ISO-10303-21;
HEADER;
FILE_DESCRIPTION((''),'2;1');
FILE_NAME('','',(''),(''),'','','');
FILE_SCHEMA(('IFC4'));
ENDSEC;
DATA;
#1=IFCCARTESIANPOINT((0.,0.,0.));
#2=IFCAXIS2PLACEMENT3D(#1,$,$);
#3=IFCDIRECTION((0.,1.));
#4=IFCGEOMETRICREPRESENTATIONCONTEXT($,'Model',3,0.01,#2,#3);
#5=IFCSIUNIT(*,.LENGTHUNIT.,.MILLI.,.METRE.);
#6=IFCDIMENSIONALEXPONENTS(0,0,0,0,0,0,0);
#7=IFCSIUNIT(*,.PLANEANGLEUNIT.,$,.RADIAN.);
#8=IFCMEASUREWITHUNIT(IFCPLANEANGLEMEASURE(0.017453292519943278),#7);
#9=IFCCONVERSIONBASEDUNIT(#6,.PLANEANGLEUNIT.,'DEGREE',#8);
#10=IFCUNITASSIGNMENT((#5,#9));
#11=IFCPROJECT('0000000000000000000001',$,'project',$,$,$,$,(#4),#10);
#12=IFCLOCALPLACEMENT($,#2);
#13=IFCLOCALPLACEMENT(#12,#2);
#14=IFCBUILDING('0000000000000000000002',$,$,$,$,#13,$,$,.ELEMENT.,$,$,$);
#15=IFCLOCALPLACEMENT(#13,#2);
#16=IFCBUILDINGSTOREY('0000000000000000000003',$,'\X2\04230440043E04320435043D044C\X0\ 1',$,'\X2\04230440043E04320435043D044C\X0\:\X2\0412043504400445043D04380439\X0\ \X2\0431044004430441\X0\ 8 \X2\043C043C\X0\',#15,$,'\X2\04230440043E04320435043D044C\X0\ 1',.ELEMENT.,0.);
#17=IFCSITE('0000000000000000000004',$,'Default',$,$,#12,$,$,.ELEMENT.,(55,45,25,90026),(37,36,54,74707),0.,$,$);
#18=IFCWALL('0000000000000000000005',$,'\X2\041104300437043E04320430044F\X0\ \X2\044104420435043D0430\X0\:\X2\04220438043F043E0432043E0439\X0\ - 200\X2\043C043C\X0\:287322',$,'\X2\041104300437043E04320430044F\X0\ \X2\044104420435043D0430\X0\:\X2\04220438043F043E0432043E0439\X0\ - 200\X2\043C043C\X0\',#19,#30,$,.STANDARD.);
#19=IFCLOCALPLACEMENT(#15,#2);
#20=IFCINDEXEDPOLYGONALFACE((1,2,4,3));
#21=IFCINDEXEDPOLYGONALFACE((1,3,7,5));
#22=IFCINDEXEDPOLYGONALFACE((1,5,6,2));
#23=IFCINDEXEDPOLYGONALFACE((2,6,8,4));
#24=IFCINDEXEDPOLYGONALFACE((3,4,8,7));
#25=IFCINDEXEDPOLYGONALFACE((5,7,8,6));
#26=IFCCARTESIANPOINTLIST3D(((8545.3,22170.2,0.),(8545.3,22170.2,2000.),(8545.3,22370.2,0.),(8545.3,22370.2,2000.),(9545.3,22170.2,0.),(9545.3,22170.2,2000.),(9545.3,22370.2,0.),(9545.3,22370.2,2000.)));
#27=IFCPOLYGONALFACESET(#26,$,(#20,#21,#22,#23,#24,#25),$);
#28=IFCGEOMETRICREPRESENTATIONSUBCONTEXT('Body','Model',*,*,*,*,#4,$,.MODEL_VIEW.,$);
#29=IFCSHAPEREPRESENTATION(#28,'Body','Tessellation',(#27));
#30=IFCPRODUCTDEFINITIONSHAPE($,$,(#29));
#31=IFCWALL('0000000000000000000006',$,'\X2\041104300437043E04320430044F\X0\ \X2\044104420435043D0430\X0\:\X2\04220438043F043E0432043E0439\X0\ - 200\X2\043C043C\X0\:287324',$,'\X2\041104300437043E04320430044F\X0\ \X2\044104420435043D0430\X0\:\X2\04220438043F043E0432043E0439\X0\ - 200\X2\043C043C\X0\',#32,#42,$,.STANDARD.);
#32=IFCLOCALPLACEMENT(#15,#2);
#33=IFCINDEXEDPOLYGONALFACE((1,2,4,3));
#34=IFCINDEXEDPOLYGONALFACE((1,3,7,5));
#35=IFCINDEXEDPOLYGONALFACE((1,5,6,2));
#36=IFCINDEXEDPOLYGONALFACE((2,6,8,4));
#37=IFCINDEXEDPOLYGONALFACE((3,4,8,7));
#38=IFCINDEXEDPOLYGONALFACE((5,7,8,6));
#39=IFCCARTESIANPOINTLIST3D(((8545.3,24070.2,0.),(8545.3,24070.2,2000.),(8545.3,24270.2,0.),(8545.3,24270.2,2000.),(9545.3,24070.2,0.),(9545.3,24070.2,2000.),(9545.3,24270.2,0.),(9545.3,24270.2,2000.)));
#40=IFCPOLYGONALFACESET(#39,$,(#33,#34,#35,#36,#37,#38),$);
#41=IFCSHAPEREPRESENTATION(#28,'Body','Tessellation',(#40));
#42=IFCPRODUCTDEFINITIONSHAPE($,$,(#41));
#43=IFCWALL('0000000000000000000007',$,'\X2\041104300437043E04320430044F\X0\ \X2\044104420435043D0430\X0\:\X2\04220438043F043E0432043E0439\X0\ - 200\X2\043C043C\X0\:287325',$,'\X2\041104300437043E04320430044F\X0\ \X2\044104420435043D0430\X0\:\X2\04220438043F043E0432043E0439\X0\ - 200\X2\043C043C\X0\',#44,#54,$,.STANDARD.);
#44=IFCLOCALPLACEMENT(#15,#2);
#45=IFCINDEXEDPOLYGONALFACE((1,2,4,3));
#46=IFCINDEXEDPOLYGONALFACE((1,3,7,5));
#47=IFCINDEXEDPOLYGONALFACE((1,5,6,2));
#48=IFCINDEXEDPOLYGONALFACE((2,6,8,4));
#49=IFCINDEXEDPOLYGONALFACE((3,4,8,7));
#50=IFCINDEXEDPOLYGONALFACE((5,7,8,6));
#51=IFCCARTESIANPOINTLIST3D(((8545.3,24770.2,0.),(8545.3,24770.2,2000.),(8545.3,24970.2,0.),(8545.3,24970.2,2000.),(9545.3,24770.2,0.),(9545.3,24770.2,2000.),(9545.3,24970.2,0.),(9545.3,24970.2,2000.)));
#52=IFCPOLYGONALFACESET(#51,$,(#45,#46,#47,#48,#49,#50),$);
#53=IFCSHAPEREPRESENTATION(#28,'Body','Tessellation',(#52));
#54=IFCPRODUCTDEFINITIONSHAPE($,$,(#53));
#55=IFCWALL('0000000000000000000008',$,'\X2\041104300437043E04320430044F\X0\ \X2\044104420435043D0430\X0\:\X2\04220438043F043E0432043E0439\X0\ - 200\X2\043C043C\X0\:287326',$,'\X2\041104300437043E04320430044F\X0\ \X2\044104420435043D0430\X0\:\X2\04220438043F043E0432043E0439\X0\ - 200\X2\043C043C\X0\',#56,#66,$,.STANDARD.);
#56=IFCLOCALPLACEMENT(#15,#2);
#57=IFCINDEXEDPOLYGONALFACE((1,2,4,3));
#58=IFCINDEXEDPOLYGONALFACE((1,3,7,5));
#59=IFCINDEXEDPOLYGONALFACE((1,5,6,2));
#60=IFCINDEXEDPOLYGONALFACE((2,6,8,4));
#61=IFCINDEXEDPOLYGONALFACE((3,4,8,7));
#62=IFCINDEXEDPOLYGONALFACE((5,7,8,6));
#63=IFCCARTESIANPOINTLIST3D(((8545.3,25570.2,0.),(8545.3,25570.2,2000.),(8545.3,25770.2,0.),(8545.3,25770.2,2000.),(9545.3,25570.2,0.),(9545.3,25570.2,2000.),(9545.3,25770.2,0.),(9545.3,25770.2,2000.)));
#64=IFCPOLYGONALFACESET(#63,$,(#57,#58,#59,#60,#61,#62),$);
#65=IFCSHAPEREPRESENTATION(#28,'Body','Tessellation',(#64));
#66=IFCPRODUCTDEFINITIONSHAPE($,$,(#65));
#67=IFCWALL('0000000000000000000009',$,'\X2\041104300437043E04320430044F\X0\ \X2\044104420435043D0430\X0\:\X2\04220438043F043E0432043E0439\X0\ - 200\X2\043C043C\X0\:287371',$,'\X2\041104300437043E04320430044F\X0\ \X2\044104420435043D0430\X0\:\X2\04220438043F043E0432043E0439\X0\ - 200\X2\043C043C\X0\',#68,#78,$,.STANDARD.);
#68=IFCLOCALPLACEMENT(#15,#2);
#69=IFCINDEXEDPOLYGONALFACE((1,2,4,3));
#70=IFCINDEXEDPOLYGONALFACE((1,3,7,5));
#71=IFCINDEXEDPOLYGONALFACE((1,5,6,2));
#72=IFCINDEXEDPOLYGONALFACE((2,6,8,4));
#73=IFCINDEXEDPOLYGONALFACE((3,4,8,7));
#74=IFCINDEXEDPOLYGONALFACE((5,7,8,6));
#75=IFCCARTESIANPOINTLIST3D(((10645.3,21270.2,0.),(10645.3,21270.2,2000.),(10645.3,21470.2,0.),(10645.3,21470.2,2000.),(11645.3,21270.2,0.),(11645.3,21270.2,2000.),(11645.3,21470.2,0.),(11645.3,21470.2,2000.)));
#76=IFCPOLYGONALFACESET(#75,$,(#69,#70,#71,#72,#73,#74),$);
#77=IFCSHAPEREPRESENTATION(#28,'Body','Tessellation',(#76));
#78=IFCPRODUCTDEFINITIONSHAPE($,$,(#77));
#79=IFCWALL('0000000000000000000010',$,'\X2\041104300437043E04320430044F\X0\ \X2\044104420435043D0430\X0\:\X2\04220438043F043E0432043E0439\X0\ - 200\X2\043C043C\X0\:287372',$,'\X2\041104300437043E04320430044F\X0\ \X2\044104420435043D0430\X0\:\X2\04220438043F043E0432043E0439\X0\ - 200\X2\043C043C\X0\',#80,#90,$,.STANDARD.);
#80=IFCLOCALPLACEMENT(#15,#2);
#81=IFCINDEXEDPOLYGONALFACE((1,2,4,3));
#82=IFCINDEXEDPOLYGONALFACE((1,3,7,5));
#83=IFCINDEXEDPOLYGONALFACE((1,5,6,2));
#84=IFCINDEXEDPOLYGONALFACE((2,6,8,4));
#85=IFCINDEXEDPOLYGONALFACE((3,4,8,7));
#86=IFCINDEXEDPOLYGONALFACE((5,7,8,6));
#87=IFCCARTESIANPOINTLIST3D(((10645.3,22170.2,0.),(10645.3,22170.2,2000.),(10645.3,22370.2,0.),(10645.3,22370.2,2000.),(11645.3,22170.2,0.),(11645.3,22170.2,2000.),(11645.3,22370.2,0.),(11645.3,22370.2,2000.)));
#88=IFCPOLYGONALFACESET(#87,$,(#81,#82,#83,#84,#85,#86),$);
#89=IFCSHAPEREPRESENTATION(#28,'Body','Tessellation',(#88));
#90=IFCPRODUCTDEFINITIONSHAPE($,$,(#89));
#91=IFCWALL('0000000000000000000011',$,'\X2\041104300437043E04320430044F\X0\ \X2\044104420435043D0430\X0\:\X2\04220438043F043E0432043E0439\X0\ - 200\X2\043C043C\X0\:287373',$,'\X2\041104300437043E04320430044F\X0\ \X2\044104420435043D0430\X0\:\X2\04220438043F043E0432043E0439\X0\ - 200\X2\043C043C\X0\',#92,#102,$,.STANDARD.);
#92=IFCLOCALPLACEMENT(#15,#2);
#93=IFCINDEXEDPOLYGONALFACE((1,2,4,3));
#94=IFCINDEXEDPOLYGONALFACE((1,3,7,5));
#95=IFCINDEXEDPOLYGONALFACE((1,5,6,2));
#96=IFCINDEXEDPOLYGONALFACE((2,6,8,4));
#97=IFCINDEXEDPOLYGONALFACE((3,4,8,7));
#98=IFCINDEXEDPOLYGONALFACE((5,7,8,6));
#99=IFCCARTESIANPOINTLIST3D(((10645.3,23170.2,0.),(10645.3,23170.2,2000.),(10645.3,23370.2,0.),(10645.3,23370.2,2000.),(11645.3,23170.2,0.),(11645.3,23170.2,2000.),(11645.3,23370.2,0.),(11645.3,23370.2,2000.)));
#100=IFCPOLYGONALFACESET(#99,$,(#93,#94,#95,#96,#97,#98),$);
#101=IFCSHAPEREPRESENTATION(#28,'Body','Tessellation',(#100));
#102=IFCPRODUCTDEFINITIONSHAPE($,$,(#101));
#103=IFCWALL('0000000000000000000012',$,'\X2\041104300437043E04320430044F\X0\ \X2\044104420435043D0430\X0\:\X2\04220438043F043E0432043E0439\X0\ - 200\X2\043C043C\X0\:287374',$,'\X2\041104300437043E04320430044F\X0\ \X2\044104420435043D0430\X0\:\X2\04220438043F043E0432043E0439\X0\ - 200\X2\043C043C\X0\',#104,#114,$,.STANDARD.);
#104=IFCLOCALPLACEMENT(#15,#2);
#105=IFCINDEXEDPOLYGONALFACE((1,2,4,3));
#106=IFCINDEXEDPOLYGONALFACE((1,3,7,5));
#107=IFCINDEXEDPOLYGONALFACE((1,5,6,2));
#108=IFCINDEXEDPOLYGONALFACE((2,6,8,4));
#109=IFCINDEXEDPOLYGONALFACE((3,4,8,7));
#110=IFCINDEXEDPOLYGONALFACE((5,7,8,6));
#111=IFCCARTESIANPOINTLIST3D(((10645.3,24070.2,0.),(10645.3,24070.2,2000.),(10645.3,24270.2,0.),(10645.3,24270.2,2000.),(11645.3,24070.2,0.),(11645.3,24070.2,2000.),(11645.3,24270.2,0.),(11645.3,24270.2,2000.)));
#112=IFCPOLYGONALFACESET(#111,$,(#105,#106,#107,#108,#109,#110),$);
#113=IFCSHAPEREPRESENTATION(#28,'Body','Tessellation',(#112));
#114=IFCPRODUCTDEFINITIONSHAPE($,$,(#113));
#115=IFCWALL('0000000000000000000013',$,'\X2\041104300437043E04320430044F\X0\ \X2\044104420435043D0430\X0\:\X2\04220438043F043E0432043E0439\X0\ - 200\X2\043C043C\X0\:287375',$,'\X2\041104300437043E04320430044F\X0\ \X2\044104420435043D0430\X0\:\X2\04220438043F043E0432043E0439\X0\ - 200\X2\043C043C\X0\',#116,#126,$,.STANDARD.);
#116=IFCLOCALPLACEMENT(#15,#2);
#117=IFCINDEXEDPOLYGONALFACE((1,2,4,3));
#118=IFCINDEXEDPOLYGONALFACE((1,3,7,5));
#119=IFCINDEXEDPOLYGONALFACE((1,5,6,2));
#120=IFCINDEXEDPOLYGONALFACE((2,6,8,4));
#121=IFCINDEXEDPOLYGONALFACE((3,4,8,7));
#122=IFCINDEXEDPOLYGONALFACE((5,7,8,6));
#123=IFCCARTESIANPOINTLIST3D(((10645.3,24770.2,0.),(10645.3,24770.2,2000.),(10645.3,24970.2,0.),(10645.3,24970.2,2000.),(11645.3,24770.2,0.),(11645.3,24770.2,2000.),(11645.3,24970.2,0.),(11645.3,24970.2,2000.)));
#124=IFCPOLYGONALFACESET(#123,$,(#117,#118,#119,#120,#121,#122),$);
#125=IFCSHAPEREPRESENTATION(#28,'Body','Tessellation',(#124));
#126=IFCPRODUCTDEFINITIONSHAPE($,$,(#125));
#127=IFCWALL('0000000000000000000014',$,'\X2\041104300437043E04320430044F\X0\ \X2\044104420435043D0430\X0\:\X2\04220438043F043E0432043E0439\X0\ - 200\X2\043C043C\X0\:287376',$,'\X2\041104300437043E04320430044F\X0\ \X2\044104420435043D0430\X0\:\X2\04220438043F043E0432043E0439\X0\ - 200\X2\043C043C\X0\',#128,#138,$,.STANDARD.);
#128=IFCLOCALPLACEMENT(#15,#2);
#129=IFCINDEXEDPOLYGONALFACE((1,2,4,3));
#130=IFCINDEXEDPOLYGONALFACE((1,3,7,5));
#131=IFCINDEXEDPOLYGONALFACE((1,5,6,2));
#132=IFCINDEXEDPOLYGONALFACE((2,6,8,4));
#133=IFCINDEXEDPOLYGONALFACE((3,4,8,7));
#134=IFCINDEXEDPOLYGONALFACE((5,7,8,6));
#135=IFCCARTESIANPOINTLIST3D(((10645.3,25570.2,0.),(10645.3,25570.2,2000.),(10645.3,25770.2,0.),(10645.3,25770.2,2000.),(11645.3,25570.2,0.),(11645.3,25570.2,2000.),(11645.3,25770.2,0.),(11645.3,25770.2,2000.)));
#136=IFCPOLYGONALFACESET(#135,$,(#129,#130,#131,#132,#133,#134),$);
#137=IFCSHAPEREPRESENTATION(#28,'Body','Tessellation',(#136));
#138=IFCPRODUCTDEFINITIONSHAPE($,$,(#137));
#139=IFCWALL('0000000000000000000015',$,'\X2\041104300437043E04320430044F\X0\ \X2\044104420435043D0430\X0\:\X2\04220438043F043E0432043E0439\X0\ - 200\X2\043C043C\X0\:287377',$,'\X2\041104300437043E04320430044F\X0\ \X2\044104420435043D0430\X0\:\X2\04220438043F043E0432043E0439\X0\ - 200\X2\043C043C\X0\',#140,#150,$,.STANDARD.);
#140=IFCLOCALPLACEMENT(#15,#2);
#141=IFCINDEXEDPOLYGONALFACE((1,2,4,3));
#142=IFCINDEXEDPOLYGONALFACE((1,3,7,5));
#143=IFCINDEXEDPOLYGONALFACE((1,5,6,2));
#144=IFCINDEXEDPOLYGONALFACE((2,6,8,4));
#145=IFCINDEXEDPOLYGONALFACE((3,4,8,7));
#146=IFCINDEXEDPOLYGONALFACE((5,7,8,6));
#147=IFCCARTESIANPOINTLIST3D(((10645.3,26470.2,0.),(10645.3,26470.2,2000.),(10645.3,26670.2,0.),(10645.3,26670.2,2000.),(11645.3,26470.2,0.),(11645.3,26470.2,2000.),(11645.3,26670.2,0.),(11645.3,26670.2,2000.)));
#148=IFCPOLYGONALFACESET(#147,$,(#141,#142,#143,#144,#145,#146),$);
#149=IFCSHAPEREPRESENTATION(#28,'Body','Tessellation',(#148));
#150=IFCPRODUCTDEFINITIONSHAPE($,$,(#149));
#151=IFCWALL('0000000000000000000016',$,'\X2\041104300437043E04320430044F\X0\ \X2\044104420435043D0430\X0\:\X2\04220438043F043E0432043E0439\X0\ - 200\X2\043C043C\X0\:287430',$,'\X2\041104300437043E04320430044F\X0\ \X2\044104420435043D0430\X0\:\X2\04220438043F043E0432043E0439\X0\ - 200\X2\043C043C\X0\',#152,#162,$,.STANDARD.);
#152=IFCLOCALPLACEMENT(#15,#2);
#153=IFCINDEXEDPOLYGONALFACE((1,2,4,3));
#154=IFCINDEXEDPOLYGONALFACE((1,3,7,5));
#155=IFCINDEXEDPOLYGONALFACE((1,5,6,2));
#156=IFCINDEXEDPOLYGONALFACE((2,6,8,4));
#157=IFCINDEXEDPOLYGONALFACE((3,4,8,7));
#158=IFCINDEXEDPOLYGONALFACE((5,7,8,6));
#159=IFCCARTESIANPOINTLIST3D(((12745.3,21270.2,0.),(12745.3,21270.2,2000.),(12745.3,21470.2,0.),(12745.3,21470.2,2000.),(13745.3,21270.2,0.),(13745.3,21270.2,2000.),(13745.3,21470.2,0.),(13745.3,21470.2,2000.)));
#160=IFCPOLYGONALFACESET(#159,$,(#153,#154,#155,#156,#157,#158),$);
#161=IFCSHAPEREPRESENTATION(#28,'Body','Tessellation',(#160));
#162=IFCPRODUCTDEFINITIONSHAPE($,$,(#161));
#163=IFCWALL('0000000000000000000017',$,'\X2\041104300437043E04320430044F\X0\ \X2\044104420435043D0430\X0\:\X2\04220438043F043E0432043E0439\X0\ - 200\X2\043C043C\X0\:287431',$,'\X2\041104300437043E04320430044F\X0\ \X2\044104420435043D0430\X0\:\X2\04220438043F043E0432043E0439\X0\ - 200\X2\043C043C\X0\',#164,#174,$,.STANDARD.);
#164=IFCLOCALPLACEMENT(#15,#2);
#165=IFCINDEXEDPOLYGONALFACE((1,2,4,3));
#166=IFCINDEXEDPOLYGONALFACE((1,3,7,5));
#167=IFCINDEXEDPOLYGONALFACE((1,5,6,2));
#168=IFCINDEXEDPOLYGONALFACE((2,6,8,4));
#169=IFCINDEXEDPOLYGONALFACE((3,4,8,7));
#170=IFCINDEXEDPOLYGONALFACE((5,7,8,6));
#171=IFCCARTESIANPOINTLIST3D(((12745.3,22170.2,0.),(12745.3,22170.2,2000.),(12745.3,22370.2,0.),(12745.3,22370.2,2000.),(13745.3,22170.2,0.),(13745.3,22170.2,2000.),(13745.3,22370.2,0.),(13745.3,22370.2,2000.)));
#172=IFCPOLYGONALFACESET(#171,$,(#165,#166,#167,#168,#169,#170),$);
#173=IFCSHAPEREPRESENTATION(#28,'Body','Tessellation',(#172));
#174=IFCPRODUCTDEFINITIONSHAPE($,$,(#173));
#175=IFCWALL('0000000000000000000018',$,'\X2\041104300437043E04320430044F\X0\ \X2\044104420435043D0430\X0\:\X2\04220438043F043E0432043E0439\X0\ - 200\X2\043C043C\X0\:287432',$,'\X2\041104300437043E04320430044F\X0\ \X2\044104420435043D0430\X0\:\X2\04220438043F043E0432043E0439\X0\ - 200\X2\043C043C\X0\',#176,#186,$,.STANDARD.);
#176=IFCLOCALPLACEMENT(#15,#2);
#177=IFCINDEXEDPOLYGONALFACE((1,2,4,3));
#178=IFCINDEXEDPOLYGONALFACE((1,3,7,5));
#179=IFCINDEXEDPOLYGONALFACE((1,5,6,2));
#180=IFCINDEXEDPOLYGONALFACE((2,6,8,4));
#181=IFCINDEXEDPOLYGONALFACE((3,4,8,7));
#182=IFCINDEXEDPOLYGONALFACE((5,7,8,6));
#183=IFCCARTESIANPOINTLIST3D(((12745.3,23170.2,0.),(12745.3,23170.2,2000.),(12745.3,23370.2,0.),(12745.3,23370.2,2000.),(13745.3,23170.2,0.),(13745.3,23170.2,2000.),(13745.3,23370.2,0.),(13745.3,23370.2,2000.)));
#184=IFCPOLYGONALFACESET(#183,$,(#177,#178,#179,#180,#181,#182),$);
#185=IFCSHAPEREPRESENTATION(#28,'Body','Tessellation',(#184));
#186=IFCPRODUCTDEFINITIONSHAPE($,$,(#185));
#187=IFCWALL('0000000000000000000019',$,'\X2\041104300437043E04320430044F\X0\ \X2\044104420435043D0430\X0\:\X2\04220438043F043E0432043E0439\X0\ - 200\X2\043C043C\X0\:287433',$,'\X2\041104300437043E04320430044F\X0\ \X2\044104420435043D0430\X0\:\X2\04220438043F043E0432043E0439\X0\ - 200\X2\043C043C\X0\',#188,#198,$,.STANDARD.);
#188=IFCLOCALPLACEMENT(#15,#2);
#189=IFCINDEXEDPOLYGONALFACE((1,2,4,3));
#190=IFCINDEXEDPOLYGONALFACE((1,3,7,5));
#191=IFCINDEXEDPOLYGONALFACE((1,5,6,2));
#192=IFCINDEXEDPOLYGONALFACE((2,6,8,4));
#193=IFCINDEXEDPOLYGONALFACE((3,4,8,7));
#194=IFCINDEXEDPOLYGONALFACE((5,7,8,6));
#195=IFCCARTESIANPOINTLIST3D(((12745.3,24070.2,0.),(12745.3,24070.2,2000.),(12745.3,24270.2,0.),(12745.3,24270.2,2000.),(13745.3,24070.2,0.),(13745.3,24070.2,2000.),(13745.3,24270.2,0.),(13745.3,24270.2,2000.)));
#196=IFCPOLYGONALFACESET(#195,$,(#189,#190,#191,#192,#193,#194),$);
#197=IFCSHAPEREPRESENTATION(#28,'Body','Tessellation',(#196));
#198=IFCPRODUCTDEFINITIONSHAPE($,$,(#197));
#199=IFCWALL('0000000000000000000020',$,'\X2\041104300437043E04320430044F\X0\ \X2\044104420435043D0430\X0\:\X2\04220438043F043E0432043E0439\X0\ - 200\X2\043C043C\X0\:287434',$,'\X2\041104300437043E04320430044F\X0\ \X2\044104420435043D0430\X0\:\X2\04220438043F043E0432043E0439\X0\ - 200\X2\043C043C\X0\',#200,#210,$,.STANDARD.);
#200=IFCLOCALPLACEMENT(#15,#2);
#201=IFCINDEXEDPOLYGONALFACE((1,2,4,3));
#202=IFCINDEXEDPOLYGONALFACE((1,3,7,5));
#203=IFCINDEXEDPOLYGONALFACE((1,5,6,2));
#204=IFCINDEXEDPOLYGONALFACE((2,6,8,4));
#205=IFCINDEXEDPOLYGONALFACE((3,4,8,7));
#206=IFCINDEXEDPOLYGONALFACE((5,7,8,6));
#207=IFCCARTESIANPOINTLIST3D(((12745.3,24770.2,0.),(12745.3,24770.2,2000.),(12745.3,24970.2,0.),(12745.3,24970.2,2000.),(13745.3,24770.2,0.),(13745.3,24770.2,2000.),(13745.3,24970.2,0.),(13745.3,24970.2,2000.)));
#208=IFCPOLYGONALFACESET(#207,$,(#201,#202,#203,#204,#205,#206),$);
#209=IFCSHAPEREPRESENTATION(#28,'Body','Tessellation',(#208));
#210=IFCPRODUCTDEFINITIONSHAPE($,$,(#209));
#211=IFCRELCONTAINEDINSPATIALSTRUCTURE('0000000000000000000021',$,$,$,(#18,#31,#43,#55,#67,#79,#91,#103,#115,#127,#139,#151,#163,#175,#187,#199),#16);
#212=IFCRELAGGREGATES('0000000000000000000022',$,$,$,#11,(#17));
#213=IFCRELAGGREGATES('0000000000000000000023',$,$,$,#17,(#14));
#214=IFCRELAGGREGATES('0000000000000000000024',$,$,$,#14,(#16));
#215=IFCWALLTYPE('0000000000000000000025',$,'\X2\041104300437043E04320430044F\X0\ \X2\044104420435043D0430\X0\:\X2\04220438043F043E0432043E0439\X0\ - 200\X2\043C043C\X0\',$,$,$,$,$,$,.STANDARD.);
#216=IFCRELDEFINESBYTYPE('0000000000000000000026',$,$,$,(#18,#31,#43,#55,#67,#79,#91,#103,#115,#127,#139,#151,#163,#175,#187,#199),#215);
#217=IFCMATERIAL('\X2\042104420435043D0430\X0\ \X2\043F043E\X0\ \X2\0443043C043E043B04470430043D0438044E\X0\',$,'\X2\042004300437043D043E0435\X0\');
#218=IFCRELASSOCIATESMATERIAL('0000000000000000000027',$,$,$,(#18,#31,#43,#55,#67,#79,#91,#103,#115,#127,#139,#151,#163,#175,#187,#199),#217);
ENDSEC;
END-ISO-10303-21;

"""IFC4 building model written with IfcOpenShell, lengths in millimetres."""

from ifc_helpers import new_model, entity, si_unit, converted_unit, direction, frame, origin, place, context, subcontext, project, spatial, indexed_curve, outline, extrude, material, type_object, element, save


model = new_model("IFC4")

# Units and contexts
model_context = context("Model", 3, precision=0.01, world=origin(), true_north=direction((0.0, 1.0)))
body_context = subcontext(model_context, "Body", "Model", "MODEL_VIEW")
ifc_project = project(units=[si_unit("LENGTHUNIT", "METRE", prefix="MILLI"), converted_unit("PLANEANGLEUNIT", "DEGREE", entity("IfcPlaneAngleMeasure", 0.017453292519943278), si_unit("PLANEANGLEUNIT", "RADIAN"), dimensions=[0, 0, 0, 0, 0, 0, 0])], contexts=[model_context])

# Site, building, storey
site_placement = place(None, origin())
site = spatial("IfcSite", under=ifc_project, at=site_placement, Name="Default", CompositionType="ELEMENT", RefLatitude=(55, 45, 25, 90026), RefLongitude=(37, 36, 54, 74707), RefElevation=0.0)
building_placement = place(site_placement, origin())
building = spatial("IfcBuilding", under=site, at=building_placement, CompositionType="ELEMENT")
storey_placement = place(building_placement, origin())
storey = spatial("IfcBuildingStorey", under=building, at=storey_placement, Name="Уровень 1", ObjectType="Уровень:Верхний брус 8 мм", LongName="Уровень 1", CompositionType="ELEMENT", Elevation=0.0)

# Walls
ifc_material = material(Name="Стена по умолчанию", Category="Разное")
wall_type = type_object("IfcWallType", Name="Базовая стена:Типовой - 200мм", PredefinedType="STANDARD")
wall_1_placement = place(storey_placement, frame((8545.3, 22270.2, 0.0)))
element("IfcWall", 1, at=wall_1_placement, inside=storey, type_object=wall_type, material=ifc_material, Name="Базовая стена:Типовой - 200мм:287322", ObjectType="Базовая стена:Типовой - 200мм", PredefinedType="STANDARD", context=body_context, shape_type="SweptSolid", body=[
    extrude(outline(indexed_curve([(1000.0, 100.0), (0.0, 100.0), (0.0, -100.0), (1000.0, -100.0), (1000.0, 100.0)], self_intersect=False)), origin(), (0.0, 0.0, 1.0), 2000.0),
])
for number, where, name in (
    (2, (8545.3, 24170.2, 0.0), "Базовая стена:Типовой - 200мм:287324"),
    (3, (8545.3, 24870.2, 0.0), "Базовая стена:Типовой - 200мм:287325"),
):
    element("IfcWall", number, at=place(storey_placement, frame(where)), inside=storey, type_object=wall_type, material=ifc_material, Name=name, ObjectType="Базовая стена:Типовой - 200мм", PredefinedType="STANDARD", context=body_context, shape_type="SweptSolid", body=[
        extrude(outline(indexed_curve([(1000.0, 100.0), (0.0, 100.0), (0.0, -100.0), (1000.0, -100.0), (1000.0, 100.0)], self_intersect=False)), origin(), (0.0, 0.0, 1.0), 2000.0),
    ])
wall_2_placement = place(storey_placement, frame((8545.3, 25670.2, 0.0)))
element("IfcWall", 4, at=wall_2_placement, inside=storey, type_object=wall_type, material=ifc_material, Name="Базовая стена:Типовой - 200мм:287326", ObjectType="Базовая стена:Типовой - 200мм", PredefinedType="STANDARD", context=body_context, shape_type="SweptSolid", body=[
    extrude(outline(indexed_curve([(1000.0, 100.0), (0.0, 100.0), (0.0, -100.0), (1000.0, -100.0), (1000.0, 100.0)], self_intersect=False)), origin(), (0.0, 0.0, 1.0), 2000.0),
])
for number, where, name in (
    (5, (10645.3, 21370.2, 0.0), "Базовая стена:Типовой - 200мм:287371"),
    (6, (10645.3, 22270.2, 0.0), "Базовая стена:Типовой - 200мм:287372"),
):
    element("IfcWall", number, at=place(storey_placement, frame(where)), inside=storey, type_object=wall_type, material=ifc_material, Name=name, ObjectType="Базовая стена:Типовой - 200мм", PredefinedType="STANDARD", context=body_context, shape_type="SweptSolid", body=[
        extrude(outline(indexed_curve([(1000.0, 100.0), (0.0, 100.0), (0.0, -100.0), (1000.0, -100.0), (1000.0, 100.0)], self_intersect=False)), origin(), (0.0, 0.0, 1.0), 2000.0),
    ])
for number, where, name in (
    (7, (10645.3, 23270.2, 0.0), "Базовая стена:Типовой - 200мм:287373"),
    (8, (10645.3, 24170.2, 0.0), "Базовая стена:Типовой - 200мм:287374"),
):
    element("IfcWall", number, at=place(storey_placement, frame(where)), inside=storey, type_object=wall_type, material=ifc_material, Name=name, ObjectType="Базовая стена:Типовой - 200мм", PredefinedType="STANDARD", context=body_context, shape_type="SweptSolid", body=[
        extrude(outline(indexed_curve([(1000.0, 100.0), (0.0, 100.0), (0.0, -100.0), (1000.0, -100.0), (1000.0, 100.0)], self_intersect=False)), origin(), (0.0, 0.0, 1.0), 2000.0),
    ])
wall_3_placement = place(storey_placement, frame((10645.3, 24870.2, 0.0)))
element("IfcWall", 9, at=wall_3_placement, inside=storey, type_object=wall_type, material=ifc_material, Name="Базовая стена:Типовой - 200мм:287375", ObjectType="Базовая стена:Типовой - 200мм", PredefinedType="STANDARD", context=body_context, shape_type="SweptSolid", body=[
    extrude(outline(indexed_curve([(1000.0, 100.0), (0.0, 100.0), (0.0, -100.0), (1000.0, -100.0), (1000.0, 100.0)], self_intersect=False)), origin(), (0.0, 0.0, 1.0), 2000.0),
])
for number, where, name in (
    (10, (10645.3, 25670.2, 0.0), "Базовая стена:Типовой - 200мм:287376"),
    (11, (10645.3, 26570.2, 0.0), "Базовая стена:Типовой - 200мм:287377"),
    (12, (12745.3, 21370.2, 0.0), "Базовая стена:Типовой - 200мм:287430"),
    (13, (12745.3, 22270.2, 0.0), "Базовая стена:Типовой - 200мм:287431"),
):
    element("IfcWall", number, at=place(storey_placement, frame(where)), inside=storey, type_object=wall_type, material=ifc_material, Name=name, ObjectType="Базовая стена:Типовой - 200мм", PredefinedType="STANDARD", context=body_context, shape_type="SweptSolid", body=[
        extrude(outline(indexed_curve([(1000.0, 100.0), (0.0, 100.0), (0.0, -100.0), (1000.0, -100.0), (1000.0, 100.0)], self_intersect=False)), origin(), (0.0, 0.0, 1.0), 2000.0),
    ])
for number, where, name in (
    (14, (12745.3, 23270.2, 0.0), "Базовая стена:Типовой - 200мм:287432"),
    (15, (12745.3, 24170.2, 0.0), "Базовая стена:Типовой - 200мм:287433"),
):
    element("IfcWall", number, at=place(storey_placement, frame(where)), inside=storey, type_object=wall_type, material=ifc_material, Name=name, ObjectType="Базовая стена:Типовой - 200мм", PredefinedType="STANDARD", context=body_context, shape_type="SweptSolid", body=[
        extrude(outline(indexed_curve([(1000.0, 100.0), (0.0, 100.0), (0.0, -100.0), (1000.0, -100.0), (1000.0, 100.0)], self_intersect=False)), origin(), (0.0, 0.0, 1.0), 2000.0),
    ])
wall_4_placement = place(storey_placement, frame((12745.3, 24870.2, 0.0)))
element("IfcWall", 16, at=wall_4_placement, inside=storey, type_object=wall_type, material=ifc_material, Name="Базовая стена:Типовой - 200мм:287434", ObjectType="Базовая стена:Типовой - 200мм", PredefinedType="STANDARD", context=body_context, shape_type="SweptSolid", body=[
    extrude(outline(indexed_curve([(1000.0, 100.0), (0.0, 100.0), (0.0, -100.0), (1000.0, -100.0), (1000.0, 100.0)], self_intersect=False)), origin(), (0.0, 0.0, 1.0), 2000.0),
])

save(model, "model.ifc")
